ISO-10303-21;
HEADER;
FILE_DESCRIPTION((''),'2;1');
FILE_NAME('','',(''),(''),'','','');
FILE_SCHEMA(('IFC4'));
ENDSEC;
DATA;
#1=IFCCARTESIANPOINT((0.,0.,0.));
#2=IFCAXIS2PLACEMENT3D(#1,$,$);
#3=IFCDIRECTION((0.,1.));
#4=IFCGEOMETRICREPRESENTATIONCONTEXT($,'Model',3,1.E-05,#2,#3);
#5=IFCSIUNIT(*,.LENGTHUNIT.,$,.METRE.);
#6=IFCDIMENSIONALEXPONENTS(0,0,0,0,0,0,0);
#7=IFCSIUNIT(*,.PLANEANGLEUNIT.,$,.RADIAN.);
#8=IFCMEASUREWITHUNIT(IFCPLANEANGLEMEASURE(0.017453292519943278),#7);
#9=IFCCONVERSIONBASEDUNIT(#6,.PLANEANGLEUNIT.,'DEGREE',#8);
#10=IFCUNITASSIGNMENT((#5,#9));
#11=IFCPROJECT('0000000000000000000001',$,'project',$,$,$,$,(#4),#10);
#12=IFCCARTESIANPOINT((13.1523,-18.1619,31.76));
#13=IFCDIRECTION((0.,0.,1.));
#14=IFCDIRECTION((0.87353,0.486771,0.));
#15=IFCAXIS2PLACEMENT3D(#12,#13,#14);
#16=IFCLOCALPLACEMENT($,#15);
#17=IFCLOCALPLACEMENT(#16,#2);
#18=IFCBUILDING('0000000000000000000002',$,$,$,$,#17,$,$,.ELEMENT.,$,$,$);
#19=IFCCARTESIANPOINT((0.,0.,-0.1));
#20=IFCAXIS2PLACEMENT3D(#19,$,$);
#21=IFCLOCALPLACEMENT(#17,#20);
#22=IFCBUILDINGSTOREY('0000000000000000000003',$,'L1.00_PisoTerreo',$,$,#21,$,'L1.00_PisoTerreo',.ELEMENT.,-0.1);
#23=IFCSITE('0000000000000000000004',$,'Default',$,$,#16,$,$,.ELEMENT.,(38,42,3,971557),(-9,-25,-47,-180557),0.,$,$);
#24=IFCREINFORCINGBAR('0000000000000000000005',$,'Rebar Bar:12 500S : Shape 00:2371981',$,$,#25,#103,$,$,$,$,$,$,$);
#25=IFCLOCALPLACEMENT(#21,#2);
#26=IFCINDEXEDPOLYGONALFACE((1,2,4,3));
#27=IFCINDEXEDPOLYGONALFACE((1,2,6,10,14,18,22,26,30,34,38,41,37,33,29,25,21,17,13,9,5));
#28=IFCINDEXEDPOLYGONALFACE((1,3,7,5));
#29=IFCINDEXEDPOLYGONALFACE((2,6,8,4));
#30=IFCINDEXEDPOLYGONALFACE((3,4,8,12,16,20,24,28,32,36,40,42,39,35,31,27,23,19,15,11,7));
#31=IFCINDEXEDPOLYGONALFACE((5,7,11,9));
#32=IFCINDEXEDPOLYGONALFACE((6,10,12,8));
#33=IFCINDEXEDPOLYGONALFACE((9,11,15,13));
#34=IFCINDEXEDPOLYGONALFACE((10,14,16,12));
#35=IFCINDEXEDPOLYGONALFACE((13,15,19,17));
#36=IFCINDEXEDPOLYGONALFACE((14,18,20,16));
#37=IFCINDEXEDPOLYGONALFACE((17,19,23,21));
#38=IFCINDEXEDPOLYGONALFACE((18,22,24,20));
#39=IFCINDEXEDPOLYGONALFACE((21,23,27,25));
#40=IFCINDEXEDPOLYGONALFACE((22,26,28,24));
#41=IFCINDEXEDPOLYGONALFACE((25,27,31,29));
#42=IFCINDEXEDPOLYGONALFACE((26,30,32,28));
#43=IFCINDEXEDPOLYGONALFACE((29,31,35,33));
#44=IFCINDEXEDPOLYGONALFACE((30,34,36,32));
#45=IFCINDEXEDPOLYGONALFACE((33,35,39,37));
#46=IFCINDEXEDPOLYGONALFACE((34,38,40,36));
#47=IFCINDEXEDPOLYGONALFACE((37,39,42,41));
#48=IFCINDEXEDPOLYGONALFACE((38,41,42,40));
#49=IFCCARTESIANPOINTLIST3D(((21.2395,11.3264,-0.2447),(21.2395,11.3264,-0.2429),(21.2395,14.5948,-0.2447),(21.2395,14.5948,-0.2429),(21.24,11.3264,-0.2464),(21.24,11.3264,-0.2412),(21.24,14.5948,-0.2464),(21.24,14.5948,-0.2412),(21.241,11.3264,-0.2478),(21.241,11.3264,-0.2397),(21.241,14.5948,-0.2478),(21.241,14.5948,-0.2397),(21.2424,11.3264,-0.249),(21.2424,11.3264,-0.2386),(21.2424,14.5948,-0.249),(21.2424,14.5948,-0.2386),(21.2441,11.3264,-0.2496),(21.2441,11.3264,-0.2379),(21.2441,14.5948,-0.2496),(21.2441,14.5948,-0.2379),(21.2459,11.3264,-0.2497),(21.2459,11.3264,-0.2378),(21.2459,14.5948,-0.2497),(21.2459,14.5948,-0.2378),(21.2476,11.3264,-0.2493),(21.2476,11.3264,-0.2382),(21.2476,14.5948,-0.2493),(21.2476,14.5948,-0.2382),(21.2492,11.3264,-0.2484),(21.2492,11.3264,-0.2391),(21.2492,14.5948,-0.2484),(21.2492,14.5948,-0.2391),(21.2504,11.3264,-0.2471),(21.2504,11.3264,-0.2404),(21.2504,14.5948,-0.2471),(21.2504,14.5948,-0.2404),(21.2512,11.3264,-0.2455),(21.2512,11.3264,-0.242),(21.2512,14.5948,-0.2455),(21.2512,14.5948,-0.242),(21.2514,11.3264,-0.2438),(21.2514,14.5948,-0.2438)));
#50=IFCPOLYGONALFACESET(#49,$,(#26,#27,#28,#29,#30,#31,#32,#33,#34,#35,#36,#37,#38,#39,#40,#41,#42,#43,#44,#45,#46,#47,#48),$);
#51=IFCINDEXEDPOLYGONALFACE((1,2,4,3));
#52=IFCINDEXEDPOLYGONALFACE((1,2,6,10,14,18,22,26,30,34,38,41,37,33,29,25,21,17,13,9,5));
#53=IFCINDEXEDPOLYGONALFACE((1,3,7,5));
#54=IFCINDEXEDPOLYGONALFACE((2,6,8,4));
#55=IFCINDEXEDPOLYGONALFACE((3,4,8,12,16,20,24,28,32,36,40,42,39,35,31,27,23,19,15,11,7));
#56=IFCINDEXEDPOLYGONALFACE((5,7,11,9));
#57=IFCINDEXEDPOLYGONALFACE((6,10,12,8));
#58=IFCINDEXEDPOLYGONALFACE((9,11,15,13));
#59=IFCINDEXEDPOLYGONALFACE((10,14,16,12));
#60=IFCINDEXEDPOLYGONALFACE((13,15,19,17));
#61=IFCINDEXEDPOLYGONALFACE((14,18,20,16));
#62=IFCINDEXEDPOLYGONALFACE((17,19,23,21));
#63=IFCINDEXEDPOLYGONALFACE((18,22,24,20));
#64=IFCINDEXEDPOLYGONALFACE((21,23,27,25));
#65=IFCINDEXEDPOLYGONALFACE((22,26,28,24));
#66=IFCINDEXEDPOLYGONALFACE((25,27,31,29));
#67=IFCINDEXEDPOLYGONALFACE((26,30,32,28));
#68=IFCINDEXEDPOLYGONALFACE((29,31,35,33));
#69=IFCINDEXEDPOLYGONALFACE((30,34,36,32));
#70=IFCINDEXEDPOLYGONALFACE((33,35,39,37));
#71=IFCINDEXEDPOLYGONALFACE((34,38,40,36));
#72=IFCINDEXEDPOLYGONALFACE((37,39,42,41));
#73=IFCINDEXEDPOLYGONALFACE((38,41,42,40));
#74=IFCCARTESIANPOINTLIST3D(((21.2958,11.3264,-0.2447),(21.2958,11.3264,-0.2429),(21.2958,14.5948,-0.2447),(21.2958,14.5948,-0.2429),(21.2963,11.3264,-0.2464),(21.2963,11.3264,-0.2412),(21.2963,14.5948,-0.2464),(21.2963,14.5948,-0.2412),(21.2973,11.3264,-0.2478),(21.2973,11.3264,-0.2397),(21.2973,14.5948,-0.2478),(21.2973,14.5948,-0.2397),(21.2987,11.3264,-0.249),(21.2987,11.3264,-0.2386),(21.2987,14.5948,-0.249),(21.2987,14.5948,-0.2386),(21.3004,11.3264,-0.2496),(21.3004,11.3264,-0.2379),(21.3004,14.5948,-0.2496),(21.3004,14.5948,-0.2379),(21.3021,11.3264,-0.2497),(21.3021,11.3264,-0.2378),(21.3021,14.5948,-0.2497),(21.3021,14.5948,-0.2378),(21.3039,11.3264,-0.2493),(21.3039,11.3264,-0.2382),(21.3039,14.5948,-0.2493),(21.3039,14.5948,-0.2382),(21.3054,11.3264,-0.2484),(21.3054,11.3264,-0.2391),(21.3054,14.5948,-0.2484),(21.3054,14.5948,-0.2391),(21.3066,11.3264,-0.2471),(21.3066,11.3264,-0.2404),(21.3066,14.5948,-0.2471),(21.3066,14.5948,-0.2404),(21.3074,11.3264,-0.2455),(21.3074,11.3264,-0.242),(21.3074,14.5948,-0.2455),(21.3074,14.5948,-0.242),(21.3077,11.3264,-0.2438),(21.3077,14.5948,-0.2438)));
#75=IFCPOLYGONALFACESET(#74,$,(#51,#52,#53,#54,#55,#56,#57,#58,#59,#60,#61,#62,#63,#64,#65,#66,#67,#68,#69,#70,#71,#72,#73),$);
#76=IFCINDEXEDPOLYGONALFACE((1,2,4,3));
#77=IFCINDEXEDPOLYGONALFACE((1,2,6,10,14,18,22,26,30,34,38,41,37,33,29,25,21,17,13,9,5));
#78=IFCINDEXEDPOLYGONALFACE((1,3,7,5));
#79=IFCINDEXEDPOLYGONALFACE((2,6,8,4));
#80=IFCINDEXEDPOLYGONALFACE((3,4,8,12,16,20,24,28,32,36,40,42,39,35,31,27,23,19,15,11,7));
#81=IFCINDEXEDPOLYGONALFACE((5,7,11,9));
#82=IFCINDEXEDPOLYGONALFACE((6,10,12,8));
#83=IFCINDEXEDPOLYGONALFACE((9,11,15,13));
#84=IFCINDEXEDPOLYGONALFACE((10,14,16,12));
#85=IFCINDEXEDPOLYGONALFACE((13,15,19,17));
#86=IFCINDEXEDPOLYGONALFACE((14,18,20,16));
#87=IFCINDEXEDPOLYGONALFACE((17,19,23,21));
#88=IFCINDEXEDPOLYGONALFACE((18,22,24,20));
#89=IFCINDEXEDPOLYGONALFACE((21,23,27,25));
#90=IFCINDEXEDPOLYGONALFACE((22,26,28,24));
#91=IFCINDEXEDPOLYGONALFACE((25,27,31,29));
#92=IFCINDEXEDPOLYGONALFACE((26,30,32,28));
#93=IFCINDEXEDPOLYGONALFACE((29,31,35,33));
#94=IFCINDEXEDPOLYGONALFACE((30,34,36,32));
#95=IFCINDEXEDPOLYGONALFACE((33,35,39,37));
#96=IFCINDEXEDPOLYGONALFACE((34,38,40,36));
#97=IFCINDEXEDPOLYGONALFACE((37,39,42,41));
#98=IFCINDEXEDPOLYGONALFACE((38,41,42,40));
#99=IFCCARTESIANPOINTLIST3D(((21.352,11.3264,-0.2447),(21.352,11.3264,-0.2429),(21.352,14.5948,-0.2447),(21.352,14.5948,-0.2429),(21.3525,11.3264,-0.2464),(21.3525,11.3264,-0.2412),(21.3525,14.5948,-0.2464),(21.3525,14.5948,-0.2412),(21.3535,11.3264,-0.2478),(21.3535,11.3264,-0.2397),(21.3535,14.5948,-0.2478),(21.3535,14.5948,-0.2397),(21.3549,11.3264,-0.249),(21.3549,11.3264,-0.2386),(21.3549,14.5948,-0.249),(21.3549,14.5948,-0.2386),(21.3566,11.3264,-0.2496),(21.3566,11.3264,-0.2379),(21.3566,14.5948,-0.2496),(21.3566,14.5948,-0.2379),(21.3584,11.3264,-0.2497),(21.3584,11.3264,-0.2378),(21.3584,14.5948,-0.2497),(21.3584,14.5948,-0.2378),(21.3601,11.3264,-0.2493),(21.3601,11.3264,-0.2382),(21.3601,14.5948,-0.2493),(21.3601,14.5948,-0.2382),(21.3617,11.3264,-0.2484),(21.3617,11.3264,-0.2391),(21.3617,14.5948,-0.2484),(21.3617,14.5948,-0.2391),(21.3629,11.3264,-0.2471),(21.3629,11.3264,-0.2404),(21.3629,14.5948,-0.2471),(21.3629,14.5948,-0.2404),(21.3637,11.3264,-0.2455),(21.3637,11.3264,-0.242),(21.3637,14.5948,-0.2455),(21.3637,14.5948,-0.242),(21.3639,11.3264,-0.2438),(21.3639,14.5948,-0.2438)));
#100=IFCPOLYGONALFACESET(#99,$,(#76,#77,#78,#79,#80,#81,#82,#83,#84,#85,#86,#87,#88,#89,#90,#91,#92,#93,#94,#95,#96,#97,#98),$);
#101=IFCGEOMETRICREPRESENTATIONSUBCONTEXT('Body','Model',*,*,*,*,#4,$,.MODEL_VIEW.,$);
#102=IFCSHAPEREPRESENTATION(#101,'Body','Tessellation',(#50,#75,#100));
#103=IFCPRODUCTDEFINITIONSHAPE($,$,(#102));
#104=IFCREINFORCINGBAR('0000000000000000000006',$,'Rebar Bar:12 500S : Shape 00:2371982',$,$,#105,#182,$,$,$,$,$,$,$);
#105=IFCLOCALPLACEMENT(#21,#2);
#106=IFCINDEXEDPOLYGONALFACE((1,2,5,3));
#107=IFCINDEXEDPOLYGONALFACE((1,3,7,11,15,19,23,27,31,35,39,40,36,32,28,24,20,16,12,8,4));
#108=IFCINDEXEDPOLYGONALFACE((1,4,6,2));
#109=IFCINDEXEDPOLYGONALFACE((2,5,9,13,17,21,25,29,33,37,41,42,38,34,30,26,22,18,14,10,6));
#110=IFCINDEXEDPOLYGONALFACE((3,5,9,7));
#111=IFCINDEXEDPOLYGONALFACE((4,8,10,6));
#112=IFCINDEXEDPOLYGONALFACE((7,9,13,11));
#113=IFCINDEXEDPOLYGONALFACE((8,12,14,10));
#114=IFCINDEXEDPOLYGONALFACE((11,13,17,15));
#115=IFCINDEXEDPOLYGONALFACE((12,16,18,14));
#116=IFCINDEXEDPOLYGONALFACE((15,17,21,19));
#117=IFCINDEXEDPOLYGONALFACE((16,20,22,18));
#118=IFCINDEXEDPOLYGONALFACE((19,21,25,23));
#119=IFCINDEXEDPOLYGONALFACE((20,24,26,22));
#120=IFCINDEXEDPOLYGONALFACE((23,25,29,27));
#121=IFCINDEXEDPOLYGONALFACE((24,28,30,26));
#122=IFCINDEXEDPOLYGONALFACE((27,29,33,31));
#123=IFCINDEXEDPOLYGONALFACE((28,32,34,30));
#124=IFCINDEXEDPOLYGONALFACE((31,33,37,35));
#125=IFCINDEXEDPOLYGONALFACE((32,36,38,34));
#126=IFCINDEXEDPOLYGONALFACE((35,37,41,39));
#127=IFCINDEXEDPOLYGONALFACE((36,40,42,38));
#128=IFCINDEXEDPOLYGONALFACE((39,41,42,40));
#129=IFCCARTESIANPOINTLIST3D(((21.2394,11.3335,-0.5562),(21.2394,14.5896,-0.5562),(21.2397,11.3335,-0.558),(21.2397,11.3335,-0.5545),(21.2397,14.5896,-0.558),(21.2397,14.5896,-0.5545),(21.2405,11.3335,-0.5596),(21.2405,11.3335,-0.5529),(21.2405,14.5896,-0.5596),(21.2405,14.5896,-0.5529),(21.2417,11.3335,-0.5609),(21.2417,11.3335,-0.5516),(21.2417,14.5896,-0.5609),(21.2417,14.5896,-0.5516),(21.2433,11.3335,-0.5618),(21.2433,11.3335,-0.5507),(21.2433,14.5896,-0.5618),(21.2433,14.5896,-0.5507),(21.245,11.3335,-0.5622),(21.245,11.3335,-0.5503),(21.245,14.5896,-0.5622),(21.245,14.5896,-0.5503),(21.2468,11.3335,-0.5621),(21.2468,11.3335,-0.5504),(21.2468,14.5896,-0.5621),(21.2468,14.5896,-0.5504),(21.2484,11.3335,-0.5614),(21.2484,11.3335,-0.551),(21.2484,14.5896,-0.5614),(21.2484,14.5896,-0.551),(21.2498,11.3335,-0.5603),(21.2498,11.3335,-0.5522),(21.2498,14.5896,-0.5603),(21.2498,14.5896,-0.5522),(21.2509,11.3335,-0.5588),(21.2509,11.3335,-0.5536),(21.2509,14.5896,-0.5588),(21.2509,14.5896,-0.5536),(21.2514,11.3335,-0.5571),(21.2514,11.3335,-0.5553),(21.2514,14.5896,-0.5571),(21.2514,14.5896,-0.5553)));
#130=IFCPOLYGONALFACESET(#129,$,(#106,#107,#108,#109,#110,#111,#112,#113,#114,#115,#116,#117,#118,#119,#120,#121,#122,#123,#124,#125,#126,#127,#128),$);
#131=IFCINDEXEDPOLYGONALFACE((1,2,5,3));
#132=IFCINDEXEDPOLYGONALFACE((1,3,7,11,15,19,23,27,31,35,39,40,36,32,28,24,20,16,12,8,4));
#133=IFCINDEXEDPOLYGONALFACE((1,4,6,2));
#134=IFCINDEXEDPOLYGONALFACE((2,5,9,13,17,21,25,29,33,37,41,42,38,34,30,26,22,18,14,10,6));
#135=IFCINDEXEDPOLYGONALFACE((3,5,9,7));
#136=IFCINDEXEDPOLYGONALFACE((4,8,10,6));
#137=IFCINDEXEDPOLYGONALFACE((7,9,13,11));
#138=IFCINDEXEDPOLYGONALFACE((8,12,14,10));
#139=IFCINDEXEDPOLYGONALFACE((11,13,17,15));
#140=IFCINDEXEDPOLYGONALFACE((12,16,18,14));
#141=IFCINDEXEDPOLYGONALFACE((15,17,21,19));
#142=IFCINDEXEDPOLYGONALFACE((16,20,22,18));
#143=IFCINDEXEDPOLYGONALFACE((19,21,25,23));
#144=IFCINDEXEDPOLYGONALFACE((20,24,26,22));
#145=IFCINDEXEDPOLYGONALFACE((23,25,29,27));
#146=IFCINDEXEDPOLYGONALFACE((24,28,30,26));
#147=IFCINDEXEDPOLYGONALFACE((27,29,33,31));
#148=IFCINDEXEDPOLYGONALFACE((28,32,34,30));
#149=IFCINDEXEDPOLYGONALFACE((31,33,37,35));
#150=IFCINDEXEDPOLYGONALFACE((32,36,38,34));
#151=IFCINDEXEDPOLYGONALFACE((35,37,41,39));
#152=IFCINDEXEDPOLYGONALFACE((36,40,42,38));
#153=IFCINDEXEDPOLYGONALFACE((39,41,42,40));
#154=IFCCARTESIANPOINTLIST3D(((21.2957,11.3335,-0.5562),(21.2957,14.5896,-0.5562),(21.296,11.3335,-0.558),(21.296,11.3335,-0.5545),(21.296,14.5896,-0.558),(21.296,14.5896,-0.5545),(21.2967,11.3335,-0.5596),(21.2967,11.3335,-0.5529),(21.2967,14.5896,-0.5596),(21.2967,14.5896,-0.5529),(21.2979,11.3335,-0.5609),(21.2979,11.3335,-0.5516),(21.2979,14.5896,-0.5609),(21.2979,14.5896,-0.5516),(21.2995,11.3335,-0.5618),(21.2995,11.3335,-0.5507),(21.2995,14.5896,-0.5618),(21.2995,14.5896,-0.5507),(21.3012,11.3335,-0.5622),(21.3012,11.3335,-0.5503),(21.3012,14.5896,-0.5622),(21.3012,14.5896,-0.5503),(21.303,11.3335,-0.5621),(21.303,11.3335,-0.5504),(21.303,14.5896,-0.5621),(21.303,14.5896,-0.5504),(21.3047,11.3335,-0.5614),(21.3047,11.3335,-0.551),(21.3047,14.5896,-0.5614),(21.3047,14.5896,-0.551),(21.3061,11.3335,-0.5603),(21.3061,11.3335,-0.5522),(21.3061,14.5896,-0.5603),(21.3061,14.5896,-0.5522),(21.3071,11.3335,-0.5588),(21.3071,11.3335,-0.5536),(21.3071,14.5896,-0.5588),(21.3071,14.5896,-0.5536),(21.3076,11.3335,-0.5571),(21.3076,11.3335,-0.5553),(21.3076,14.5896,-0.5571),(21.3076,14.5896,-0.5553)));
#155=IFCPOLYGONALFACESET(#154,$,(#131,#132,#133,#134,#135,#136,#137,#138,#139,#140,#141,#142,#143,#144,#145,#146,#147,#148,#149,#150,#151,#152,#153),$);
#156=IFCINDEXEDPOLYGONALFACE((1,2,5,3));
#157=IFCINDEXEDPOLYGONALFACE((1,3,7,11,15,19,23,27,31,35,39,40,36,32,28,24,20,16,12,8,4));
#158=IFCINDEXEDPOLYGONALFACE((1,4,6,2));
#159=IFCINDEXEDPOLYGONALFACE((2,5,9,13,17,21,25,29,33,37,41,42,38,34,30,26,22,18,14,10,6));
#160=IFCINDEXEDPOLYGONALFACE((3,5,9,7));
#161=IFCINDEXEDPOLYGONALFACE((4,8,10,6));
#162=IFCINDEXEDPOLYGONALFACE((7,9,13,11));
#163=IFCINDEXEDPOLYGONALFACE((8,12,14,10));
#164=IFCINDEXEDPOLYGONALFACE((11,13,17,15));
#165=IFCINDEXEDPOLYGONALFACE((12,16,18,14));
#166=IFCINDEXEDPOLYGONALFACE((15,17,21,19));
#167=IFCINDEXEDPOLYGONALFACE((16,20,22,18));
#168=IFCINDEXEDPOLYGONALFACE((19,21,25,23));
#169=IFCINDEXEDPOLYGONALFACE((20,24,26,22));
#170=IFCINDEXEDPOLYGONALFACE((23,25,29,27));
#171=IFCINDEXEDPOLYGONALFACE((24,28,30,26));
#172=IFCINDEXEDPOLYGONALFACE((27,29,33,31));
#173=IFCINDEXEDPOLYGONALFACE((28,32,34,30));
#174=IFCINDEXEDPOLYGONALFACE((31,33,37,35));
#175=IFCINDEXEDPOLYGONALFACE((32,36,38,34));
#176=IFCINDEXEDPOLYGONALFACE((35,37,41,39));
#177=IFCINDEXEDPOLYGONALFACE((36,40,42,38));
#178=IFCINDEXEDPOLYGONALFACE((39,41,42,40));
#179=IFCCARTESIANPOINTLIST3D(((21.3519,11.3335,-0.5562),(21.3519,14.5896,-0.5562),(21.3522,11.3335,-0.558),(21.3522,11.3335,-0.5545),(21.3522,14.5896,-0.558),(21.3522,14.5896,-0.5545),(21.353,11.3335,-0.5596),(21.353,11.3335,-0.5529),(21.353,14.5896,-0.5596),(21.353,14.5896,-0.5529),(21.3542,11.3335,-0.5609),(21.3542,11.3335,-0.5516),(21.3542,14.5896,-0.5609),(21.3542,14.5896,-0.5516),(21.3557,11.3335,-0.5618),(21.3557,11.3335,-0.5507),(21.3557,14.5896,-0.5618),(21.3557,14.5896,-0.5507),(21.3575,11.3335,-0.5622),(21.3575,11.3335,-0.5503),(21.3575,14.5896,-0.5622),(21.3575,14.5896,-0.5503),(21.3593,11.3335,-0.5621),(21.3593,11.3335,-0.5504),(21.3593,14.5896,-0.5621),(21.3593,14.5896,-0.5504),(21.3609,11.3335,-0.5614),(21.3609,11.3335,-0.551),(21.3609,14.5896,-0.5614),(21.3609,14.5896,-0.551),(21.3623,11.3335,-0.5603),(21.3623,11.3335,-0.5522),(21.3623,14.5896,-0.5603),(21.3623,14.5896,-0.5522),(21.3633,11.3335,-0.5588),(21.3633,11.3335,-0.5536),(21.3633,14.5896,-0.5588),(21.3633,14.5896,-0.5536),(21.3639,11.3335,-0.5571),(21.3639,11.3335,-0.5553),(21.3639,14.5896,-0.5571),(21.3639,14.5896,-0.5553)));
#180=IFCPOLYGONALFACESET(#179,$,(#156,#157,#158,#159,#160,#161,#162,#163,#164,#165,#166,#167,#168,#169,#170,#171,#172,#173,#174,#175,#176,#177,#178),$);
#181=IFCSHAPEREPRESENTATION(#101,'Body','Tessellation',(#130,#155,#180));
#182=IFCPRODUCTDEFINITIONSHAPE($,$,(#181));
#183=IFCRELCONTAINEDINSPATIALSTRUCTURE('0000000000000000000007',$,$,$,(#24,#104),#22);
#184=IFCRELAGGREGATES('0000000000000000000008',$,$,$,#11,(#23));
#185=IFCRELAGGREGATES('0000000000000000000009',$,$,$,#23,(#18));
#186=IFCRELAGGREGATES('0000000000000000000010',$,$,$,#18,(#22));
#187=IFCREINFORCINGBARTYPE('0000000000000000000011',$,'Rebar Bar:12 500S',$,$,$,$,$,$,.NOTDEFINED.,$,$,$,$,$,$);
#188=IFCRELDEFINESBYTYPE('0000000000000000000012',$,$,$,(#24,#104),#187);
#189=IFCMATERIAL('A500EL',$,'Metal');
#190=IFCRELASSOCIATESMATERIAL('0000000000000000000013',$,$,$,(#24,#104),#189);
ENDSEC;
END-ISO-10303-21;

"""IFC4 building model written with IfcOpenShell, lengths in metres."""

from ifc_helpers import new_model, entity, si_unit, converted_unit, direction, frame, origin, place, context, subcontext, project, spatial, material, type_object, element, save


model = new_model("IFC4")

# Units and contexts
model_context = context("Model", 3, precision=1e-05, world=origin(), true_north=direction((0.0, 1.0)))
body_context = subcontext(model_context, "Body", "Model", "MODEL_VIEW")
ifc_project = project(units=[si_unit("LENGTHUNIT", "METRE"), converted_unit("PLANEANGLEUNIT", "DEGREE", entity("IfcPlaneAngleMeasure", 0.017453292519943278), si_unit("PLANEANGLEUNIT", "RADIAN"), dimensions=[0, 0, 0, 0, 0, 0, 0])], contexts=[model_context])

# Site, building, storey
site_placement = place(None, frame((13.1523, -18.1619, 31.76), z_axis=(0.0, 0.0, 1.0), x_axis=(0.87353, 0.486771, 0.0)))
site = spatial("IfcSite", under=ifc_project, at=site_placement, Name="Default", CompositionType="ELEMENT", RefLatitude=(38, 42, 3, 971557), RefLongitude=(-9, -25, -47, -180557), RefElevation=0.0)
building_placement = place(site_placement, origin())
building = spatial("IfcBuilding", under=site, at=building_placement, CompositionType="ELEMENT")
storey_placement = place(building_placement, frame((0.0, 0.0, -0.1)))
storey = spatial("IfcBuildingStorey", under=building, at=storey_placement, Name="L1.00_PisoTerreo", LongName="L1.00_PisoTerreo", CompositionType="ELEMENT", Elevation=-0.1)

# Reinforcing bars
ifc_material = material(Name="A500EL", Category="Metal")
reinforcing_bar_type_1 = type_object("IfcReinforcingBarType", Name="Rebar Bar:12 500S", PredefinedType="NOTDEFINED")
reinforcing_bar_1_placement = place(storey_placement, origin())
element("IfcReinforcingBar", 1, at=reinforcing_bar_1_placement, inside=storey, type_object=reinforcing_bar_type_1, material=ifc_material, Name="Rebar Bar:12 500S : Shape 00:2371981", context=body_context, shape_type="AdvancedSweptSolid", body=[
    entity("IfcSweptDiskSolid", entity("IfcIndexedPolyCurve", entity("IfcCartesianPointList3D", [[21.2454, 11.3264, -0.2438], [21.2454, 14.5948, -0.2438]]), None, False), 0.006, None, 0.0, 1.0),
    entity("IfcSweptDiskSolid", entity("IfcIndexedPolyCurve", entity("IfcCartesianPointList3D", [[21.3017, 11.3264, -0.2438], [21.3017, 14.5948, -0.2438]]), None, False), 0.006, None, 0.0, 1.0),
    entity("IfcSweptDiskSolid", entity("IfcIndexedPolyCurve", entity("IfcCartesianPointList3D", [[21.3579, 11.3264, -0.2438], [21.3579, 14.5948, -0.2438]]), None, False), 0.006, None, 0.0, 1.0),
])
reinforcing_bar_2_placement = place(storey_placement, origin())
element("IfcReinforcingBar", 2, at=reinforcing_bar_2_placement, inside=storey, type_object=reinforcing_bar_type_1, material=ifc_material, Name="Rebar Bar:12 500S : Shape 00:2371982", context=body_context, shape_type="AdvancedSweptSolid", body=[
    entity("IfcSweptDiskSolid", entity("IfcIndexedPolyCurve", entity("IfcCartesianPointList3D", [[21.2454, 14.5896, -0.5562], [21.2454, 11.3335, -0.5562]]), None, False), 0.006, None, 0.0, 1.0),
    entity("IfcSweptDiskSolid", entity("IfcIndexedPolyCurve", entity("IfcCartesianPointList3D", [[21.3017, 14.5896, -0.5562], [21.3017, 11.3335, -0.5562]]), None, False), 0.006, None, 0.0, 1.0),
    entity("IfcSweptDiskSolid", entity("IfcIndexedPolyCurve", entity("IfcCartesianPointList3D", [[21.3579, 14.5896, -0.5562], [21.3579, 11.3335, -0.5562]]), None, False), 0.006, None, 0.0, 1.0),
])

save(model, "model.ifc")
